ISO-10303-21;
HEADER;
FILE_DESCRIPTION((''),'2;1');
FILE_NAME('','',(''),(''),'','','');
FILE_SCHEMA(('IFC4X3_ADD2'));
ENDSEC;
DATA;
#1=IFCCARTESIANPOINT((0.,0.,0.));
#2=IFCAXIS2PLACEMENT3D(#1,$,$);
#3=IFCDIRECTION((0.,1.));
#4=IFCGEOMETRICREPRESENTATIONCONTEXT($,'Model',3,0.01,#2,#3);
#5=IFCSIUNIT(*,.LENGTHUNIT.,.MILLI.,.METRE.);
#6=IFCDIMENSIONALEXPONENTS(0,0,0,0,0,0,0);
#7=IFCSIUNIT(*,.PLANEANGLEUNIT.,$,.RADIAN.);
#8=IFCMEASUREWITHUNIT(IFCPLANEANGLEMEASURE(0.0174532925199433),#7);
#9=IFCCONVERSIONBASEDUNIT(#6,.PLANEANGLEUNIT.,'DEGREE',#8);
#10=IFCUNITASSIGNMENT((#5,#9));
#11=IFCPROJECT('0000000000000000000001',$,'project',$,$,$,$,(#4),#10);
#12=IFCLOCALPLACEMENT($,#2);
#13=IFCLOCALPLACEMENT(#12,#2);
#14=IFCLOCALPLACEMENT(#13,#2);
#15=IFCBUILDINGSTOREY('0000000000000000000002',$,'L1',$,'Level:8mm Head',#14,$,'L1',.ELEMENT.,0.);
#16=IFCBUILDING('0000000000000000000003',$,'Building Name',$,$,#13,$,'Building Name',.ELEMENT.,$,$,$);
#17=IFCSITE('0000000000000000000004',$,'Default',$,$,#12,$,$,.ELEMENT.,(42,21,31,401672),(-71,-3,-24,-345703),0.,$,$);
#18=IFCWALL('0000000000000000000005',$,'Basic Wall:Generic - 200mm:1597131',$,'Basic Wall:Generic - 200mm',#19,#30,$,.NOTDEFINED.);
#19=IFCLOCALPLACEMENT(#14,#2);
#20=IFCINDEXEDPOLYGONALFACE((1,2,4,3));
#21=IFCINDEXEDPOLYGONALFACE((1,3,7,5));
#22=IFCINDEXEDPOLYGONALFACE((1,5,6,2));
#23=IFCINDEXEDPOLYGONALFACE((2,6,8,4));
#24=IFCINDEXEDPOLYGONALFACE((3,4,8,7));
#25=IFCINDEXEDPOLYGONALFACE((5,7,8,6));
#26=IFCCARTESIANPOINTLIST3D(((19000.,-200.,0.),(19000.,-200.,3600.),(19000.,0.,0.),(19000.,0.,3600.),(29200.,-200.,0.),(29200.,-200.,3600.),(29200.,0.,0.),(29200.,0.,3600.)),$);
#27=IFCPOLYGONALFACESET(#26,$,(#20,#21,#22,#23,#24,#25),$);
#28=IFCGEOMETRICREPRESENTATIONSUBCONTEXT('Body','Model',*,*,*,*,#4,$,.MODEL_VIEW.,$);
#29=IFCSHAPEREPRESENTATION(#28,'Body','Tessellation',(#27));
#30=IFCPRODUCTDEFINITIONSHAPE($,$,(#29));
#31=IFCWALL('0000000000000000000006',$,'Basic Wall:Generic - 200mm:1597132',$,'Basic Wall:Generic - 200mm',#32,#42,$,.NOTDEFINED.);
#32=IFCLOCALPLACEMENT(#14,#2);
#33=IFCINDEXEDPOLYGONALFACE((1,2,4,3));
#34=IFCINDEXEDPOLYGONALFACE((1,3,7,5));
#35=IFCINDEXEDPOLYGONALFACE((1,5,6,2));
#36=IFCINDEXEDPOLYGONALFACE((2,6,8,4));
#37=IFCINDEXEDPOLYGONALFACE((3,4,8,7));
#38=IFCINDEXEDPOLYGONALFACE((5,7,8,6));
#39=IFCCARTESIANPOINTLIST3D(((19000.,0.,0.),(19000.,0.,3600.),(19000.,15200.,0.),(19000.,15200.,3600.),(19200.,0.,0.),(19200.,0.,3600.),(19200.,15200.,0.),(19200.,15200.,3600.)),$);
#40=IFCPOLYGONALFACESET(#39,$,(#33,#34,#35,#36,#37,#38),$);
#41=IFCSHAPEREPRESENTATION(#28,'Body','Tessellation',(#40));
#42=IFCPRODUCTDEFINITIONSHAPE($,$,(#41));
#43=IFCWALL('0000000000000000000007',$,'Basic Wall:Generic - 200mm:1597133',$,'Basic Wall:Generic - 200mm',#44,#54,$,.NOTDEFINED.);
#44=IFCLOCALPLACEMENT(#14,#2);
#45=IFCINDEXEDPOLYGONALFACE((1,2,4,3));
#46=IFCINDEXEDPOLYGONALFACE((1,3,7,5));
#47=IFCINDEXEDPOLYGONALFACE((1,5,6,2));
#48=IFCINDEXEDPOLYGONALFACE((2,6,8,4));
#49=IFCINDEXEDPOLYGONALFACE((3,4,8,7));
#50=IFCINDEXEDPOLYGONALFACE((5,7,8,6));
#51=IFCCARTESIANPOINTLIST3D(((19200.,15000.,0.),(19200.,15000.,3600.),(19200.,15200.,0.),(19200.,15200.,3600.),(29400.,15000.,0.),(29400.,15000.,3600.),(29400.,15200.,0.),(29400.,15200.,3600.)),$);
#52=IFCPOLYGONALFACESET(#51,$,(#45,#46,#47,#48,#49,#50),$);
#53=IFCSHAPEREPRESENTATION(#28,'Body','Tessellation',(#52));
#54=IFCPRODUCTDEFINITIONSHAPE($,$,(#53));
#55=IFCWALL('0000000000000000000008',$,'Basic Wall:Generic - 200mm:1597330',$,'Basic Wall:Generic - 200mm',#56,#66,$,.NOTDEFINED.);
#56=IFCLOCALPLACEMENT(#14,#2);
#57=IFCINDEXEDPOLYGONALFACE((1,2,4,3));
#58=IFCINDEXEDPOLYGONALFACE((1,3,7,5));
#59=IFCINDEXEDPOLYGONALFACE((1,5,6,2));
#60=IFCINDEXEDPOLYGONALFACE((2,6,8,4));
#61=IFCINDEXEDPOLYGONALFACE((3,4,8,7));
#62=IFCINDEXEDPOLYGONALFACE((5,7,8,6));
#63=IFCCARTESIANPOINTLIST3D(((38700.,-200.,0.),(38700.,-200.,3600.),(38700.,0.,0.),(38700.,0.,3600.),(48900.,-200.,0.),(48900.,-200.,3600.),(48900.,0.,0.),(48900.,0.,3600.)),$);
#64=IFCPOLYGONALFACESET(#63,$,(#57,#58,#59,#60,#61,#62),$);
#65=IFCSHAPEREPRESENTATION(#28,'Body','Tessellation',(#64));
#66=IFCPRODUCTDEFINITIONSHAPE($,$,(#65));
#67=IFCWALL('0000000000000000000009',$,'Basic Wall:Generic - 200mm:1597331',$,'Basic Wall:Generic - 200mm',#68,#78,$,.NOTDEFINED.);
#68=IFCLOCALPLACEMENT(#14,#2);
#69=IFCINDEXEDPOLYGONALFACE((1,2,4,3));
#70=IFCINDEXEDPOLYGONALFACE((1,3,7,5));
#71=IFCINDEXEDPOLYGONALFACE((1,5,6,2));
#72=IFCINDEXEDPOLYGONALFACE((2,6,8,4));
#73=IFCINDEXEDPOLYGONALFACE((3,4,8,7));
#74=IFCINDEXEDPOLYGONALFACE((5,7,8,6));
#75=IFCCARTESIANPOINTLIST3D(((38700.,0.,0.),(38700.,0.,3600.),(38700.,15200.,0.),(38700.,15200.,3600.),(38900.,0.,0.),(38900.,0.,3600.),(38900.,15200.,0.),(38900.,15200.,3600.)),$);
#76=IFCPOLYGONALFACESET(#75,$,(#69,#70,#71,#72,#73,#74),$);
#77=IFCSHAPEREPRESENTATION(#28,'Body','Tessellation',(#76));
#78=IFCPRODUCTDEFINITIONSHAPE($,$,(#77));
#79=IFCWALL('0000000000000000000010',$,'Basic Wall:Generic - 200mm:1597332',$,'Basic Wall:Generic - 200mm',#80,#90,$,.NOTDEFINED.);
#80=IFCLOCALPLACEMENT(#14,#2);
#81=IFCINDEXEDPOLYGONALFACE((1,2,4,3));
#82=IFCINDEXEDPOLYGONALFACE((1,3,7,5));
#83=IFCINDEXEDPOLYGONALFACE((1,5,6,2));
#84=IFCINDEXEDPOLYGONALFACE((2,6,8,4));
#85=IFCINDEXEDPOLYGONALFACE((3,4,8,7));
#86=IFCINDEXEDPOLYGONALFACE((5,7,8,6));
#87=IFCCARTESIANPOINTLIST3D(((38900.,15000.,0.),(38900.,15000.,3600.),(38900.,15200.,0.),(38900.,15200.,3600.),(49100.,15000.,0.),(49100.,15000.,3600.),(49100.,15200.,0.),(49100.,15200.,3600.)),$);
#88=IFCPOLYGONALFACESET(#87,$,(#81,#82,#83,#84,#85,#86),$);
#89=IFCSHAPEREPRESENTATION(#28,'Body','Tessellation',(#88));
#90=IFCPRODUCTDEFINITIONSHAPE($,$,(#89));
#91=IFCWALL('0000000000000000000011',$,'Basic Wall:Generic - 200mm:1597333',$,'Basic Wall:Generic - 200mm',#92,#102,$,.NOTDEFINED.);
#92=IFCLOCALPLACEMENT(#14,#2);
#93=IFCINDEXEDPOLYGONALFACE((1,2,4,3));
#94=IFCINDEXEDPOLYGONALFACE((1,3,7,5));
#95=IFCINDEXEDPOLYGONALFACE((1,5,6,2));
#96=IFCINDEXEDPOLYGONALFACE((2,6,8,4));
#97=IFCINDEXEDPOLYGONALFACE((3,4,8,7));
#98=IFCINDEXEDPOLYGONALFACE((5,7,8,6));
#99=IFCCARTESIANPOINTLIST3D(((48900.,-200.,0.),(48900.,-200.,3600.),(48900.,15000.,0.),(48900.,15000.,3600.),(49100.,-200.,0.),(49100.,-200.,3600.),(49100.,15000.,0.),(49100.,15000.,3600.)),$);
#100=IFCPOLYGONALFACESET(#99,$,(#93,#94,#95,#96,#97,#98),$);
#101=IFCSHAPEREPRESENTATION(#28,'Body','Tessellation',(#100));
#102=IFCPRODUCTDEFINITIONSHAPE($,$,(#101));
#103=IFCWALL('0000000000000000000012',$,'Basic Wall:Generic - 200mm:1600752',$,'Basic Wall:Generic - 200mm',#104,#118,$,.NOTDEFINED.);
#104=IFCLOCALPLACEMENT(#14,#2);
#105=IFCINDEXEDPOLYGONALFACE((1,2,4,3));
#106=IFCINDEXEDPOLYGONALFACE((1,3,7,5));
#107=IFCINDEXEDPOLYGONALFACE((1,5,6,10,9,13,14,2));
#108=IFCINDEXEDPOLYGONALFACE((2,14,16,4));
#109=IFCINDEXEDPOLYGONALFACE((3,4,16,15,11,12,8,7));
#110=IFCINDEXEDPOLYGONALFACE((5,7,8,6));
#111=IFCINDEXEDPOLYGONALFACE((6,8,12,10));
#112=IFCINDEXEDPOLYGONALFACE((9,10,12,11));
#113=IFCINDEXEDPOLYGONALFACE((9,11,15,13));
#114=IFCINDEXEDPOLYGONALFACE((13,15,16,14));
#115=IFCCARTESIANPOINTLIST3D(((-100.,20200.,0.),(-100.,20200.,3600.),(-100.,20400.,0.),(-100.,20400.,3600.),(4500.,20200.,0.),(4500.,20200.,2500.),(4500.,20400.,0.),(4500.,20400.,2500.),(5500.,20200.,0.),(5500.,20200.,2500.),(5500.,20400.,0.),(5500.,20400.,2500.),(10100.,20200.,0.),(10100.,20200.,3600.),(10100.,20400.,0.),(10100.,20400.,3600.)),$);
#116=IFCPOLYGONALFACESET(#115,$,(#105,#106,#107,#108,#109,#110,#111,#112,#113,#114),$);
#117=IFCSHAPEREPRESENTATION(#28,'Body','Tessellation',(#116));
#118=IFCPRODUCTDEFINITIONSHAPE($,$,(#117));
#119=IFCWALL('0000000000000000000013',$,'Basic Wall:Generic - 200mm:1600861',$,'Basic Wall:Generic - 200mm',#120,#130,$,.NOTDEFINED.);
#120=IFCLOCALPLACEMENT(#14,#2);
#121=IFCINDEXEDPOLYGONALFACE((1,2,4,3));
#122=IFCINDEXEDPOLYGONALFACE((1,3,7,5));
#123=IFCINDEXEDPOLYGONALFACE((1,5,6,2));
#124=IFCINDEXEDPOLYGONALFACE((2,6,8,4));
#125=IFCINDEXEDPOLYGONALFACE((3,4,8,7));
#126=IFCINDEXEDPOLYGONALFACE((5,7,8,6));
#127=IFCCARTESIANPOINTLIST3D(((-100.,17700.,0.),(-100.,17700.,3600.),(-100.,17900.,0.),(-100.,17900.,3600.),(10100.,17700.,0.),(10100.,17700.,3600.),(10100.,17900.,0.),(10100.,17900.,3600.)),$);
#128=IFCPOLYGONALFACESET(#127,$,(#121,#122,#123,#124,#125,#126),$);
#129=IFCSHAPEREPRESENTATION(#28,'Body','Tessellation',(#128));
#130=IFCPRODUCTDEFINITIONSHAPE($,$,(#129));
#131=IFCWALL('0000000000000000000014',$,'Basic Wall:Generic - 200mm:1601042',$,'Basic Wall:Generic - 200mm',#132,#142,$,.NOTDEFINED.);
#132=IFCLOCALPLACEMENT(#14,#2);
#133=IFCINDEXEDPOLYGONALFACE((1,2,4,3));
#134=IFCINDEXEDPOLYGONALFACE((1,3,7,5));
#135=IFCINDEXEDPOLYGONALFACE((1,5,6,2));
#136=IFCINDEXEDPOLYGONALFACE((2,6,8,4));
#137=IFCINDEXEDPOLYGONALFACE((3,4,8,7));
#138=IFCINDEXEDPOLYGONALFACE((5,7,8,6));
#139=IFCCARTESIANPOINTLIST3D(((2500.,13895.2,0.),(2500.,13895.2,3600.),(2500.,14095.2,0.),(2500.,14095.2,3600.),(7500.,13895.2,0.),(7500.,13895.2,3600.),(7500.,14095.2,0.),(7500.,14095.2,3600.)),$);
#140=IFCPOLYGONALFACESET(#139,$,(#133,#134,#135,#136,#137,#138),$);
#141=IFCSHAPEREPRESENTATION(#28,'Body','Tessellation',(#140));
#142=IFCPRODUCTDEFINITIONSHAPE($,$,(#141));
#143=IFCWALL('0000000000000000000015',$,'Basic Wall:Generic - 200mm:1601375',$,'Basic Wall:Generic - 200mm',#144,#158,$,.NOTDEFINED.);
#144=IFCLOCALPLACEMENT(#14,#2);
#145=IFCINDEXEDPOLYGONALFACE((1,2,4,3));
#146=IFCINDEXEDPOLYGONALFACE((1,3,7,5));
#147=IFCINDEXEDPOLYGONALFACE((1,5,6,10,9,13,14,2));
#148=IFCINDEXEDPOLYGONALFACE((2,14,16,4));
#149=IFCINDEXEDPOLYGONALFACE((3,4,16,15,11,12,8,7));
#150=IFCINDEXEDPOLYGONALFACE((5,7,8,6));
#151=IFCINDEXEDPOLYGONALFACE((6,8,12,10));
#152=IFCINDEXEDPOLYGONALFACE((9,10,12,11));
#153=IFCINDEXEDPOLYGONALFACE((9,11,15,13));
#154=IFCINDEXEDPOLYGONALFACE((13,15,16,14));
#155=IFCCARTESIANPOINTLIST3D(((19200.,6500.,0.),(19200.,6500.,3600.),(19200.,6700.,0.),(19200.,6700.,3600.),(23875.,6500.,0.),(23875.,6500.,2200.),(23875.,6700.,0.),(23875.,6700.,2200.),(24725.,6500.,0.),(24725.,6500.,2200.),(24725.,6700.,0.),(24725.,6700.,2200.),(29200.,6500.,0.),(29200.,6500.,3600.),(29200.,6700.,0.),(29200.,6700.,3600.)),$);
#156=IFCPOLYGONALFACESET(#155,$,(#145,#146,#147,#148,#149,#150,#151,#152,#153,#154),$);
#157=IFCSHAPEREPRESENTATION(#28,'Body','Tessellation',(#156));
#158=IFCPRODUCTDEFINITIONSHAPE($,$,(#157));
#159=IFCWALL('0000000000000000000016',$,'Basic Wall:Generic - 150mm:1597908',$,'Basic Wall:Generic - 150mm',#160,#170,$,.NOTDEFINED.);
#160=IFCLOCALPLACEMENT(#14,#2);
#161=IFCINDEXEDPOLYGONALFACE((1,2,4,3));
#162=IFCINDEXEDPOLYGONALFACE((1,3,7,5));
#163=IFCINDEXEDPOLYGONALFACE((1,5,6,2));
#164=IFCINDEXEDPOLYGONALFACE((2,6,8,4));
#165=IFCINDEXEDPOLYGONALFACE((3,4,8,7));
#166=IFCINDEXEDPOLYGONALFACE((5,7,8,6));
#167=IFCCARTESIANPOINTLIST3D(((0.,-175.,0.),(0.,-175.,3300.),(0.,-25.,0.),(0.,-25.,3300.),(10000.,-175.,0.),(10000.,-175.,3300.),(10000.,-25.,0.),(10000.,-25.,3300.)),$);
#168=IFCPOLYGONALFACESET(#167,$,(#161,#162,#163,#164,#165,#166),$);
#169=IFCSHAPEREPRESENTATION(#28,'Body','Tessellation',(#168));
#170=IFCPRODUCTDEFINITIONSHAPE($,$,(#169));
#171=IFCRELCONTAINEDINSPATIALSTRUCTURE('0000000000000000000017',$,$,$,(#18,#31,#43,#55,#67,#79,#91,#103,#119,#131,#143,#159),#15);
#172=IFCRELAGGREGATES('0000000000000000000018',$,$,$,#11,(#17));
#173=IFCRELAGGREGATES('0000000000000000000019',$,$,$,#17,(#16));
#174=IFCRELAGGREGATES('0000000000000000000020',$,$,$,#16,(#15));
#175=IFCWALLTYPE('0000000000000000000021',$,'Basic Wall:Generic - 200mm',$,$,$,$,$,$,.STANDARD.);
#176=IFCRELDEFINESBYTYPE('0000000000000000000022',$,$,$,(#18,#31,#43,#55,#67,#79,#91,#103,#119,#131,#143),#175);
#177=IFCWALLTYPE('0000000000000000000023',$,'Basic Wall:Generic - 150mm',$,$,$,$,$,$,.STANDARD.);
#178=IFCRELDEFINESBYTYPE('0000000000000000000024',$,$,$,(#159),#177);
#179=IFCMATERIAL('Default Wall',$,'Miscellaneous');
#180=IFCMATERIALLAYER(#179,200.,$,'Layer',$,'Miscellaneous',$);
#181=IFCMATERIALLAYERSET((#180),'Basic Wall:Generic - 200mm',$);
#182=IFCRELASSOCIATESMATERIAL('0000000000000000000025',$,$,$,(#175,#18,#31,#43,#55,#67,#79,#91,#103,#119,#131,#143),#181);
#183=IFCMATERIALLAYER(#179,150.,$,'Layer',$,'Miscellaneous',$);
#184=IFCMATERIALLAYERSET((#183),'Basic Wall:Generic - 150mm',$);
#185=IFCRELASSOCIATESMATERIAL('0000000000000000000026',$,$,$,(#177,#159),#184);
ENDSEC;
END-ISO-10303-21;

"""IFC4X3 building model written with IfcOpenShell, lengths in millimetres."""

from ifc_helpers import new_model, entity, si_unit, converted_unit, direction, frame, frame_2d, origin, origin_2d_with_axis, place, context, subcontext, project, spatial, rectangle, extrude, material, layer, layer_set, type_object, element, save


model = new_model("IFC4X3")

# Units and contexts
model_context = context("Model", 3, precision=0.01, world=origin(), true_north=direction((0.0, 1.0)))
body_context = subcontext(model_context, "Body", "Model", "MODEL_VIEW")
ifc_project = project(units=[si_unit("LENGTHUNIT", "METRE", prefix="MILLI"), converted_unit("PLANEANGLEUNIT", "DEGREE", entity("IfcPlaneAngleMeasure", 0.0174532925199433), si_unit("PLANEANGLEUNIT", "RADIAN"), dimensions=[0, 0, 0, 0, 0, 0, 0])], contexts=[model_context])

# Site, building, storey
site_placement = place(None, origin())
site = spatial("IfcSite", under=ifc_project, at=site_placement, Name="Default", CompositionType="ELEMENT", RefLatitude=(42, 21, 31, 401672), RefLongitude=(-71, -3, -24, -345703), RefElevation=0.0)
building_placement = place(site_placement, origin())
building = spatial("IfcBuilding", under=site, at=building_placement, Name="Building Name", LongName="Building Name", CompositionType="ELEMENT")
storey_placement = place(building_placement, origin())
storey = spatial("IfcBuildingStorey", under=building, at=storey_placement, Name="L1", ObjectType="Level:8mm Head", LongName="L1", CompositionType="ELEMENT", Elevation=0.0)

# Walls
ifc_material_1 = material(Name="Default Wall", Category="Miscellaneous")
ifc_layer_1 = layer(ifc_material_1, 200.0, Name="Layer", Category="Miscellaneous")
ifc_layer_set_1 = layer_set([ifc_layer_1], Name="Basic Wall:Generic - 200mm")
wall_type_1 = type_object("IfcWallType", Name="Basic Wall:Generic - 200mm", PredefinedType="STANDARD", material=ifc_layer_set_1)
wall_1_placement = place(storey_placement, frame((19000.0, -100.0, 0.0)))
element("IfcWall", 1, at=wall_1_placement, inside=storey, type_object=wall_type_1, material=ifc_layer_set_1, Name="Basic Wall:Generic - 200mm:1597131", ObjectType="Basic Wall:Generic - 200mm", PredefinedType="NOTDEFINED", context=body_context, shape_type="SweptSolid", body=[
    extrude(rectangle(XDim=10200.0, YDim=200.0, at=frame_2d((5100.0, 0.0), x_axis=(-1.0, 0.0))), origin(), (0.0, 0.0, 1.0), 3600.0),
])
wall_2_placement = place(storey_placement, frame((19100.0, 15200.0, 0.0), z_axis=(0.0, 0.0, 1.0), x_axis=(0.0, -1.0, 0.0)))
element("IfcWall", 2, at=wall_2_placement, inside=storey, type_object=wall_type_1, material=ifc_layer_set_1, Name="Basic Wall:Generic - 200mm:1597132", ObjectType="Basic Wall:Generic - 200mm", PredefinedType="NOTDEFINED", context=body_context, shape_type="SweptSolid", body=[
    extrude(rectangle(XDim=15200.0, YDim=200.0, at=frame_2d((7600.0, 0.0), x_axis=(-1.0, 0.0))), origin(), (0.0, 0.0, 1.0), 3600.0),
])
wall_3_placement = place(storey_placement, frame((29400.0, 15100.0, 0.0), z_axis=(0.0, 0.0, 1.0), x_axis=(-1.0, 0.0, 0.0)))
element("IfcWall", 3, at=wall_3_placement, inside=storey, type_object=wall_type_1, material=ifc_layer_set_1, Name="Basic Wall:Generic - 200mm:1597133", ObjectType="Basic Wall:Generic - 200mm", PredefinedType="NOTDEFINED", context=body_context, shape_type="SweptSolid", body=[
    extrude(rectangle(XDim=10200.0, YDim=200.0, at=frame_2d((5100.0, 0.0), x_axis=(-1.0, 0.0))), origin(), (0.0, 0.0, 1.0), 3600.0),
])
wall_4_placement = place(storey_placement, frame((38700.0, -100.0, 0.0)))
element("IfcWall", 4, at=wall_4_placement, inside=storey, type_object=wall_type_1, material=ifc_layer_set_1, Name="Basic Wall:Generic - 200mm:1597330", ObjectType="Basic Wall:Generic - 200mm", PredefinedType="NOTDEFINED", context=body_context, shape_type="SweptSolid", body=[
    extrude(rectangle(XDim=10200.0, YDim=200.0, at=frame_2d((5100.0, 0.0), x_axis=(-1.0, 0.0))), origin(), (0.0, 0.0, 1.0), 3600.0),
])
wall_5_placement = place(storey_placement, frame((38800.0, 15200.0, 0.0), z_axis=(0.0, 0.0, 1.0), x_axis=(0.0, -1.0, 0.0)))
element("IfcWall", 5, at=wall_5_placement, inside=storey, type_object=wall_type_1, material=ifc_layer_set_1, Name="Basic Wall:Generic - 200mm:1597331", ObjectType="Basic Wall:Generic - 200mm", PredefinedType="NOTDEFINED", context=body_context, shape_type="SweptSolid", body=[
    extrude(rectangle(XDim=15200.0, YDim=200.0, at=frame_2d((7600.0, 0.0), x_axis=(-1.0, 0.0))), origin(), (0.0, 0.0, 1.0), 3600.0),
])
wall_6_placement = place(storey_placement, frame((49100.0, 15100.0, 0.0), z_axis=(0.0, 0.0, 1.0), x_axis=(-1.0, 0.0, 0.0)))
element("IfcWall", 6, at=wall_6_placement, inside=storey, type_object=wall_type_1, material=ifc_layer_set_1, Name="Basic Wall:Generic - 200mm:1597332", ObjectType="Basic Wall:Generic - 200mm", PredefinedType="NOTDEFINED", context=body_context, shape_type="SweptSolid", body=[
    extrude(rectangle(XDim=10200.0, YDim=200.0, at=frame_2d((5100.0, 0.0), x_axis=(-1.0, 0.0))), origin(), (0.0, 0.0, 1.0), 3600.0),
])
wall_7_placement = place(storey_placement, frame((49000.0, -200.0, 0.0), z_axis=(0.0, 0.0, 1.0), x_axis=(0.0, 1.0, 0.0)))
element("IfcWall", 7, at=wall_7_placement, inside=storey, type_object=wall_type_1, material=ifc_layer_set_1, Name="Basic Wall:Generic - 200mm:1597333", ObjectType="Basic Wall:Generic - 200mm", PredefinedType="NOTDEFINED", context=body_context, shape_type="SweptSolid", body=[
    extrude(rectangle(XDim=15200.0, YDim=200.0, at=frame_2d((7600.0, 0.0), x_axis=(-1.0, 0.0))), origin(), (0.0, 0.0, 1.0), 3600.0),
])

# Wall, opening
wall_8_placement = place(storey_placement, frame((10100.0, 20300.0, 0.0), z_axis=(0.0, 0.0, 1.0), x_axis=(-1.0, 0.0, 0.0)))
wall_8 = element("IfcWall", 8, at=wall_8_placement, inside=storey, type_object=wall_type_1, material=ifc_layer_set_1, Name="Basic Wall:Generic - 200mm:1600752", ObjectType="Basic Wall:Generic - 200mm", PredefinedType="NOTDEFINED", context=body_context, shape_type="SweptSolid", body=[
    extrude(rectangle(XDim=10200.0, YDim=200.0, at=frame_2d((5100.0, 0.0), x_axis=(1.0, 0.0))), origin(), (0.0, 0.0, 1.0), 3600.0),
])
opening_1_placement = place(wall_8_placement, frame((5600.0, 100.0, 0.0)))
element("IfcOpeningElement", 9, at=opening_1_placement, cuts=wall_8, PredefinedType="OPENING", context=body_context, shape_type="SweptSolid", body=[
    extrude(rectangle(XDim=2500.0, YDim=1000.0, at=origin_2d_with_axis()), frame((-500.0, -200.0, 1250.0), z_axis=(0.0, 1.0, 0.0), x_axis=(0.0, 0.0, -1.0)), (0.0, 0.0, 1.0), 200.0),
])

# Walls
wall_9_placement = place(storey_placement, frame((10100.0, 17800.0, 0.0), z_axis=(0.0, 0.0, 1.0), x_axis=(-1.0, 0.0, 0.0)))
element("IfcWall", 10, at=wall_9_placement, inside=storey, type_object=wall_type_1, material=ifc_layer_set_1, Name="Basic Wall:Generic - 200mm:1600861", ObjectType="Basic Wall:Generic - 200mm", PredefinedType="NOTDEFINED", context=body_context, shape_type="SweptSolid", body=[
    extrude(rectangle(XDim=10200.0, YDim=200.0, at=frame_2d((5100.0, 0.0), x_axis=(-1.0, 0.0))), origin(), (0.0, 0.0, 1.0), 3600.0),
])
wall_10_placement = place(storey_placement, frame((7500.0, 13995.2, 0.0), z_axis=(0.0, 0.0, 1.0), x_axis=(-1.0, 0.0, 0.0)))
element("IfcWall", 11, at=wall_10_placement, inside=storey, type_object=wall_type_1, material=ifc_layer_set_1, Name="Basic Wall:Generic - 200mm:1601042", ObjectType="Basic Wall:Generic - 200mm", PredefinedType="NOTDEFINED", context=body_context, shape_type="SweptSolid", body=[
    extrude(rectangle(XDim=5000.0, YDim=200.0, at=frame_2d((2500.0, 0.0), x_axis=(-1.0, 0.0))), origin(), (0.0, 0.0, 1.0), 3600.0),
])

# Wall, opening
wall_11_placement = place(storey_placement, frame((29200.0, 6600.0, 0.0), z_axis=(0.0, 0.0, 1.0), x_axis=(-1.0, 0.0, 0.0)))
wall_11 = element("IfcWall", 12, at=wall_11_placement, inside=storey, type_object=wall_type_1, material=ifc_layer_set_1, Name="Basic Wall:Generic - 200mm:1601375", ObjectType="Basic Wall:Generic - 200mm", PredefinedType="NOTDEFINED", context=body_context, shape_type="SweptSolid", body=[
    extrude(rectangle(XDim=10000.0, YDim=200.0, at=frame_2d((5000.0, 0.0), x_axis=(1.0, 0.0))), origin(), (0.0, 0.0, 1.0), 3600.0),
])
opening_2_placement = place(wall_11_placement, frame((5325.0, 100.0, 0.0)))
element("IfcOpeningElement", 13, at=opening_2_placement, cuts=wall_11, PredefinedType="OPENING", context=body_context, shape_type="SweptSolid", body=[
    extrude(rectangle(XDim=2200.0, YDim=850.0, at=frame_2d((1100.0, 425.0), x_axis=(1.0, 0.0))), frame((0.0, 0.0, 0.0), z_axis=(0.0, -1.0, 0.0), x_axis=(0.0, 0.0, 1.0)), (0.0, 0.0, 1.0), 200.0),
])

# Wall
ifc_layer_2 = layer(ifc_material_1, 150.0, Name="Layer", Category="Miscellaneous")
ifc_layer_set_2 = layer_set([ifc_layer_2], Name="Basic Wall:Generic - 150mm")
wall_type_2 = type_object("IfcWallType", Name="Basic Wall:Generic - 150mm", PredefinedType="STANDARD", material=ifc_layer_set_2)
wall_12_placement = place(storey_placement, frame((0.0, -100.0, 0.0)))
element("IfcWall", 14, at=wall_12_placement, inside=storey, type_object=wall_type_2, material=ifc_layer_set_2, Name="Basic Wall:Generic - 150mm:1597908", ObjectType="Basic Wall:Generic - 150mm", PredefinedType="NOTDEFINED", context=body_context, shape_type="SweptSolid", body=[
    extrude(rectangle(XDim=10000.0, YDim=150.0, at=frame_2d((5000.0, 0.0), x_axis=(-1.0, 0.0))), origin(), (0.0, 0.0, 1.0), 3300.0),
])

save(model, "model.ifc")
